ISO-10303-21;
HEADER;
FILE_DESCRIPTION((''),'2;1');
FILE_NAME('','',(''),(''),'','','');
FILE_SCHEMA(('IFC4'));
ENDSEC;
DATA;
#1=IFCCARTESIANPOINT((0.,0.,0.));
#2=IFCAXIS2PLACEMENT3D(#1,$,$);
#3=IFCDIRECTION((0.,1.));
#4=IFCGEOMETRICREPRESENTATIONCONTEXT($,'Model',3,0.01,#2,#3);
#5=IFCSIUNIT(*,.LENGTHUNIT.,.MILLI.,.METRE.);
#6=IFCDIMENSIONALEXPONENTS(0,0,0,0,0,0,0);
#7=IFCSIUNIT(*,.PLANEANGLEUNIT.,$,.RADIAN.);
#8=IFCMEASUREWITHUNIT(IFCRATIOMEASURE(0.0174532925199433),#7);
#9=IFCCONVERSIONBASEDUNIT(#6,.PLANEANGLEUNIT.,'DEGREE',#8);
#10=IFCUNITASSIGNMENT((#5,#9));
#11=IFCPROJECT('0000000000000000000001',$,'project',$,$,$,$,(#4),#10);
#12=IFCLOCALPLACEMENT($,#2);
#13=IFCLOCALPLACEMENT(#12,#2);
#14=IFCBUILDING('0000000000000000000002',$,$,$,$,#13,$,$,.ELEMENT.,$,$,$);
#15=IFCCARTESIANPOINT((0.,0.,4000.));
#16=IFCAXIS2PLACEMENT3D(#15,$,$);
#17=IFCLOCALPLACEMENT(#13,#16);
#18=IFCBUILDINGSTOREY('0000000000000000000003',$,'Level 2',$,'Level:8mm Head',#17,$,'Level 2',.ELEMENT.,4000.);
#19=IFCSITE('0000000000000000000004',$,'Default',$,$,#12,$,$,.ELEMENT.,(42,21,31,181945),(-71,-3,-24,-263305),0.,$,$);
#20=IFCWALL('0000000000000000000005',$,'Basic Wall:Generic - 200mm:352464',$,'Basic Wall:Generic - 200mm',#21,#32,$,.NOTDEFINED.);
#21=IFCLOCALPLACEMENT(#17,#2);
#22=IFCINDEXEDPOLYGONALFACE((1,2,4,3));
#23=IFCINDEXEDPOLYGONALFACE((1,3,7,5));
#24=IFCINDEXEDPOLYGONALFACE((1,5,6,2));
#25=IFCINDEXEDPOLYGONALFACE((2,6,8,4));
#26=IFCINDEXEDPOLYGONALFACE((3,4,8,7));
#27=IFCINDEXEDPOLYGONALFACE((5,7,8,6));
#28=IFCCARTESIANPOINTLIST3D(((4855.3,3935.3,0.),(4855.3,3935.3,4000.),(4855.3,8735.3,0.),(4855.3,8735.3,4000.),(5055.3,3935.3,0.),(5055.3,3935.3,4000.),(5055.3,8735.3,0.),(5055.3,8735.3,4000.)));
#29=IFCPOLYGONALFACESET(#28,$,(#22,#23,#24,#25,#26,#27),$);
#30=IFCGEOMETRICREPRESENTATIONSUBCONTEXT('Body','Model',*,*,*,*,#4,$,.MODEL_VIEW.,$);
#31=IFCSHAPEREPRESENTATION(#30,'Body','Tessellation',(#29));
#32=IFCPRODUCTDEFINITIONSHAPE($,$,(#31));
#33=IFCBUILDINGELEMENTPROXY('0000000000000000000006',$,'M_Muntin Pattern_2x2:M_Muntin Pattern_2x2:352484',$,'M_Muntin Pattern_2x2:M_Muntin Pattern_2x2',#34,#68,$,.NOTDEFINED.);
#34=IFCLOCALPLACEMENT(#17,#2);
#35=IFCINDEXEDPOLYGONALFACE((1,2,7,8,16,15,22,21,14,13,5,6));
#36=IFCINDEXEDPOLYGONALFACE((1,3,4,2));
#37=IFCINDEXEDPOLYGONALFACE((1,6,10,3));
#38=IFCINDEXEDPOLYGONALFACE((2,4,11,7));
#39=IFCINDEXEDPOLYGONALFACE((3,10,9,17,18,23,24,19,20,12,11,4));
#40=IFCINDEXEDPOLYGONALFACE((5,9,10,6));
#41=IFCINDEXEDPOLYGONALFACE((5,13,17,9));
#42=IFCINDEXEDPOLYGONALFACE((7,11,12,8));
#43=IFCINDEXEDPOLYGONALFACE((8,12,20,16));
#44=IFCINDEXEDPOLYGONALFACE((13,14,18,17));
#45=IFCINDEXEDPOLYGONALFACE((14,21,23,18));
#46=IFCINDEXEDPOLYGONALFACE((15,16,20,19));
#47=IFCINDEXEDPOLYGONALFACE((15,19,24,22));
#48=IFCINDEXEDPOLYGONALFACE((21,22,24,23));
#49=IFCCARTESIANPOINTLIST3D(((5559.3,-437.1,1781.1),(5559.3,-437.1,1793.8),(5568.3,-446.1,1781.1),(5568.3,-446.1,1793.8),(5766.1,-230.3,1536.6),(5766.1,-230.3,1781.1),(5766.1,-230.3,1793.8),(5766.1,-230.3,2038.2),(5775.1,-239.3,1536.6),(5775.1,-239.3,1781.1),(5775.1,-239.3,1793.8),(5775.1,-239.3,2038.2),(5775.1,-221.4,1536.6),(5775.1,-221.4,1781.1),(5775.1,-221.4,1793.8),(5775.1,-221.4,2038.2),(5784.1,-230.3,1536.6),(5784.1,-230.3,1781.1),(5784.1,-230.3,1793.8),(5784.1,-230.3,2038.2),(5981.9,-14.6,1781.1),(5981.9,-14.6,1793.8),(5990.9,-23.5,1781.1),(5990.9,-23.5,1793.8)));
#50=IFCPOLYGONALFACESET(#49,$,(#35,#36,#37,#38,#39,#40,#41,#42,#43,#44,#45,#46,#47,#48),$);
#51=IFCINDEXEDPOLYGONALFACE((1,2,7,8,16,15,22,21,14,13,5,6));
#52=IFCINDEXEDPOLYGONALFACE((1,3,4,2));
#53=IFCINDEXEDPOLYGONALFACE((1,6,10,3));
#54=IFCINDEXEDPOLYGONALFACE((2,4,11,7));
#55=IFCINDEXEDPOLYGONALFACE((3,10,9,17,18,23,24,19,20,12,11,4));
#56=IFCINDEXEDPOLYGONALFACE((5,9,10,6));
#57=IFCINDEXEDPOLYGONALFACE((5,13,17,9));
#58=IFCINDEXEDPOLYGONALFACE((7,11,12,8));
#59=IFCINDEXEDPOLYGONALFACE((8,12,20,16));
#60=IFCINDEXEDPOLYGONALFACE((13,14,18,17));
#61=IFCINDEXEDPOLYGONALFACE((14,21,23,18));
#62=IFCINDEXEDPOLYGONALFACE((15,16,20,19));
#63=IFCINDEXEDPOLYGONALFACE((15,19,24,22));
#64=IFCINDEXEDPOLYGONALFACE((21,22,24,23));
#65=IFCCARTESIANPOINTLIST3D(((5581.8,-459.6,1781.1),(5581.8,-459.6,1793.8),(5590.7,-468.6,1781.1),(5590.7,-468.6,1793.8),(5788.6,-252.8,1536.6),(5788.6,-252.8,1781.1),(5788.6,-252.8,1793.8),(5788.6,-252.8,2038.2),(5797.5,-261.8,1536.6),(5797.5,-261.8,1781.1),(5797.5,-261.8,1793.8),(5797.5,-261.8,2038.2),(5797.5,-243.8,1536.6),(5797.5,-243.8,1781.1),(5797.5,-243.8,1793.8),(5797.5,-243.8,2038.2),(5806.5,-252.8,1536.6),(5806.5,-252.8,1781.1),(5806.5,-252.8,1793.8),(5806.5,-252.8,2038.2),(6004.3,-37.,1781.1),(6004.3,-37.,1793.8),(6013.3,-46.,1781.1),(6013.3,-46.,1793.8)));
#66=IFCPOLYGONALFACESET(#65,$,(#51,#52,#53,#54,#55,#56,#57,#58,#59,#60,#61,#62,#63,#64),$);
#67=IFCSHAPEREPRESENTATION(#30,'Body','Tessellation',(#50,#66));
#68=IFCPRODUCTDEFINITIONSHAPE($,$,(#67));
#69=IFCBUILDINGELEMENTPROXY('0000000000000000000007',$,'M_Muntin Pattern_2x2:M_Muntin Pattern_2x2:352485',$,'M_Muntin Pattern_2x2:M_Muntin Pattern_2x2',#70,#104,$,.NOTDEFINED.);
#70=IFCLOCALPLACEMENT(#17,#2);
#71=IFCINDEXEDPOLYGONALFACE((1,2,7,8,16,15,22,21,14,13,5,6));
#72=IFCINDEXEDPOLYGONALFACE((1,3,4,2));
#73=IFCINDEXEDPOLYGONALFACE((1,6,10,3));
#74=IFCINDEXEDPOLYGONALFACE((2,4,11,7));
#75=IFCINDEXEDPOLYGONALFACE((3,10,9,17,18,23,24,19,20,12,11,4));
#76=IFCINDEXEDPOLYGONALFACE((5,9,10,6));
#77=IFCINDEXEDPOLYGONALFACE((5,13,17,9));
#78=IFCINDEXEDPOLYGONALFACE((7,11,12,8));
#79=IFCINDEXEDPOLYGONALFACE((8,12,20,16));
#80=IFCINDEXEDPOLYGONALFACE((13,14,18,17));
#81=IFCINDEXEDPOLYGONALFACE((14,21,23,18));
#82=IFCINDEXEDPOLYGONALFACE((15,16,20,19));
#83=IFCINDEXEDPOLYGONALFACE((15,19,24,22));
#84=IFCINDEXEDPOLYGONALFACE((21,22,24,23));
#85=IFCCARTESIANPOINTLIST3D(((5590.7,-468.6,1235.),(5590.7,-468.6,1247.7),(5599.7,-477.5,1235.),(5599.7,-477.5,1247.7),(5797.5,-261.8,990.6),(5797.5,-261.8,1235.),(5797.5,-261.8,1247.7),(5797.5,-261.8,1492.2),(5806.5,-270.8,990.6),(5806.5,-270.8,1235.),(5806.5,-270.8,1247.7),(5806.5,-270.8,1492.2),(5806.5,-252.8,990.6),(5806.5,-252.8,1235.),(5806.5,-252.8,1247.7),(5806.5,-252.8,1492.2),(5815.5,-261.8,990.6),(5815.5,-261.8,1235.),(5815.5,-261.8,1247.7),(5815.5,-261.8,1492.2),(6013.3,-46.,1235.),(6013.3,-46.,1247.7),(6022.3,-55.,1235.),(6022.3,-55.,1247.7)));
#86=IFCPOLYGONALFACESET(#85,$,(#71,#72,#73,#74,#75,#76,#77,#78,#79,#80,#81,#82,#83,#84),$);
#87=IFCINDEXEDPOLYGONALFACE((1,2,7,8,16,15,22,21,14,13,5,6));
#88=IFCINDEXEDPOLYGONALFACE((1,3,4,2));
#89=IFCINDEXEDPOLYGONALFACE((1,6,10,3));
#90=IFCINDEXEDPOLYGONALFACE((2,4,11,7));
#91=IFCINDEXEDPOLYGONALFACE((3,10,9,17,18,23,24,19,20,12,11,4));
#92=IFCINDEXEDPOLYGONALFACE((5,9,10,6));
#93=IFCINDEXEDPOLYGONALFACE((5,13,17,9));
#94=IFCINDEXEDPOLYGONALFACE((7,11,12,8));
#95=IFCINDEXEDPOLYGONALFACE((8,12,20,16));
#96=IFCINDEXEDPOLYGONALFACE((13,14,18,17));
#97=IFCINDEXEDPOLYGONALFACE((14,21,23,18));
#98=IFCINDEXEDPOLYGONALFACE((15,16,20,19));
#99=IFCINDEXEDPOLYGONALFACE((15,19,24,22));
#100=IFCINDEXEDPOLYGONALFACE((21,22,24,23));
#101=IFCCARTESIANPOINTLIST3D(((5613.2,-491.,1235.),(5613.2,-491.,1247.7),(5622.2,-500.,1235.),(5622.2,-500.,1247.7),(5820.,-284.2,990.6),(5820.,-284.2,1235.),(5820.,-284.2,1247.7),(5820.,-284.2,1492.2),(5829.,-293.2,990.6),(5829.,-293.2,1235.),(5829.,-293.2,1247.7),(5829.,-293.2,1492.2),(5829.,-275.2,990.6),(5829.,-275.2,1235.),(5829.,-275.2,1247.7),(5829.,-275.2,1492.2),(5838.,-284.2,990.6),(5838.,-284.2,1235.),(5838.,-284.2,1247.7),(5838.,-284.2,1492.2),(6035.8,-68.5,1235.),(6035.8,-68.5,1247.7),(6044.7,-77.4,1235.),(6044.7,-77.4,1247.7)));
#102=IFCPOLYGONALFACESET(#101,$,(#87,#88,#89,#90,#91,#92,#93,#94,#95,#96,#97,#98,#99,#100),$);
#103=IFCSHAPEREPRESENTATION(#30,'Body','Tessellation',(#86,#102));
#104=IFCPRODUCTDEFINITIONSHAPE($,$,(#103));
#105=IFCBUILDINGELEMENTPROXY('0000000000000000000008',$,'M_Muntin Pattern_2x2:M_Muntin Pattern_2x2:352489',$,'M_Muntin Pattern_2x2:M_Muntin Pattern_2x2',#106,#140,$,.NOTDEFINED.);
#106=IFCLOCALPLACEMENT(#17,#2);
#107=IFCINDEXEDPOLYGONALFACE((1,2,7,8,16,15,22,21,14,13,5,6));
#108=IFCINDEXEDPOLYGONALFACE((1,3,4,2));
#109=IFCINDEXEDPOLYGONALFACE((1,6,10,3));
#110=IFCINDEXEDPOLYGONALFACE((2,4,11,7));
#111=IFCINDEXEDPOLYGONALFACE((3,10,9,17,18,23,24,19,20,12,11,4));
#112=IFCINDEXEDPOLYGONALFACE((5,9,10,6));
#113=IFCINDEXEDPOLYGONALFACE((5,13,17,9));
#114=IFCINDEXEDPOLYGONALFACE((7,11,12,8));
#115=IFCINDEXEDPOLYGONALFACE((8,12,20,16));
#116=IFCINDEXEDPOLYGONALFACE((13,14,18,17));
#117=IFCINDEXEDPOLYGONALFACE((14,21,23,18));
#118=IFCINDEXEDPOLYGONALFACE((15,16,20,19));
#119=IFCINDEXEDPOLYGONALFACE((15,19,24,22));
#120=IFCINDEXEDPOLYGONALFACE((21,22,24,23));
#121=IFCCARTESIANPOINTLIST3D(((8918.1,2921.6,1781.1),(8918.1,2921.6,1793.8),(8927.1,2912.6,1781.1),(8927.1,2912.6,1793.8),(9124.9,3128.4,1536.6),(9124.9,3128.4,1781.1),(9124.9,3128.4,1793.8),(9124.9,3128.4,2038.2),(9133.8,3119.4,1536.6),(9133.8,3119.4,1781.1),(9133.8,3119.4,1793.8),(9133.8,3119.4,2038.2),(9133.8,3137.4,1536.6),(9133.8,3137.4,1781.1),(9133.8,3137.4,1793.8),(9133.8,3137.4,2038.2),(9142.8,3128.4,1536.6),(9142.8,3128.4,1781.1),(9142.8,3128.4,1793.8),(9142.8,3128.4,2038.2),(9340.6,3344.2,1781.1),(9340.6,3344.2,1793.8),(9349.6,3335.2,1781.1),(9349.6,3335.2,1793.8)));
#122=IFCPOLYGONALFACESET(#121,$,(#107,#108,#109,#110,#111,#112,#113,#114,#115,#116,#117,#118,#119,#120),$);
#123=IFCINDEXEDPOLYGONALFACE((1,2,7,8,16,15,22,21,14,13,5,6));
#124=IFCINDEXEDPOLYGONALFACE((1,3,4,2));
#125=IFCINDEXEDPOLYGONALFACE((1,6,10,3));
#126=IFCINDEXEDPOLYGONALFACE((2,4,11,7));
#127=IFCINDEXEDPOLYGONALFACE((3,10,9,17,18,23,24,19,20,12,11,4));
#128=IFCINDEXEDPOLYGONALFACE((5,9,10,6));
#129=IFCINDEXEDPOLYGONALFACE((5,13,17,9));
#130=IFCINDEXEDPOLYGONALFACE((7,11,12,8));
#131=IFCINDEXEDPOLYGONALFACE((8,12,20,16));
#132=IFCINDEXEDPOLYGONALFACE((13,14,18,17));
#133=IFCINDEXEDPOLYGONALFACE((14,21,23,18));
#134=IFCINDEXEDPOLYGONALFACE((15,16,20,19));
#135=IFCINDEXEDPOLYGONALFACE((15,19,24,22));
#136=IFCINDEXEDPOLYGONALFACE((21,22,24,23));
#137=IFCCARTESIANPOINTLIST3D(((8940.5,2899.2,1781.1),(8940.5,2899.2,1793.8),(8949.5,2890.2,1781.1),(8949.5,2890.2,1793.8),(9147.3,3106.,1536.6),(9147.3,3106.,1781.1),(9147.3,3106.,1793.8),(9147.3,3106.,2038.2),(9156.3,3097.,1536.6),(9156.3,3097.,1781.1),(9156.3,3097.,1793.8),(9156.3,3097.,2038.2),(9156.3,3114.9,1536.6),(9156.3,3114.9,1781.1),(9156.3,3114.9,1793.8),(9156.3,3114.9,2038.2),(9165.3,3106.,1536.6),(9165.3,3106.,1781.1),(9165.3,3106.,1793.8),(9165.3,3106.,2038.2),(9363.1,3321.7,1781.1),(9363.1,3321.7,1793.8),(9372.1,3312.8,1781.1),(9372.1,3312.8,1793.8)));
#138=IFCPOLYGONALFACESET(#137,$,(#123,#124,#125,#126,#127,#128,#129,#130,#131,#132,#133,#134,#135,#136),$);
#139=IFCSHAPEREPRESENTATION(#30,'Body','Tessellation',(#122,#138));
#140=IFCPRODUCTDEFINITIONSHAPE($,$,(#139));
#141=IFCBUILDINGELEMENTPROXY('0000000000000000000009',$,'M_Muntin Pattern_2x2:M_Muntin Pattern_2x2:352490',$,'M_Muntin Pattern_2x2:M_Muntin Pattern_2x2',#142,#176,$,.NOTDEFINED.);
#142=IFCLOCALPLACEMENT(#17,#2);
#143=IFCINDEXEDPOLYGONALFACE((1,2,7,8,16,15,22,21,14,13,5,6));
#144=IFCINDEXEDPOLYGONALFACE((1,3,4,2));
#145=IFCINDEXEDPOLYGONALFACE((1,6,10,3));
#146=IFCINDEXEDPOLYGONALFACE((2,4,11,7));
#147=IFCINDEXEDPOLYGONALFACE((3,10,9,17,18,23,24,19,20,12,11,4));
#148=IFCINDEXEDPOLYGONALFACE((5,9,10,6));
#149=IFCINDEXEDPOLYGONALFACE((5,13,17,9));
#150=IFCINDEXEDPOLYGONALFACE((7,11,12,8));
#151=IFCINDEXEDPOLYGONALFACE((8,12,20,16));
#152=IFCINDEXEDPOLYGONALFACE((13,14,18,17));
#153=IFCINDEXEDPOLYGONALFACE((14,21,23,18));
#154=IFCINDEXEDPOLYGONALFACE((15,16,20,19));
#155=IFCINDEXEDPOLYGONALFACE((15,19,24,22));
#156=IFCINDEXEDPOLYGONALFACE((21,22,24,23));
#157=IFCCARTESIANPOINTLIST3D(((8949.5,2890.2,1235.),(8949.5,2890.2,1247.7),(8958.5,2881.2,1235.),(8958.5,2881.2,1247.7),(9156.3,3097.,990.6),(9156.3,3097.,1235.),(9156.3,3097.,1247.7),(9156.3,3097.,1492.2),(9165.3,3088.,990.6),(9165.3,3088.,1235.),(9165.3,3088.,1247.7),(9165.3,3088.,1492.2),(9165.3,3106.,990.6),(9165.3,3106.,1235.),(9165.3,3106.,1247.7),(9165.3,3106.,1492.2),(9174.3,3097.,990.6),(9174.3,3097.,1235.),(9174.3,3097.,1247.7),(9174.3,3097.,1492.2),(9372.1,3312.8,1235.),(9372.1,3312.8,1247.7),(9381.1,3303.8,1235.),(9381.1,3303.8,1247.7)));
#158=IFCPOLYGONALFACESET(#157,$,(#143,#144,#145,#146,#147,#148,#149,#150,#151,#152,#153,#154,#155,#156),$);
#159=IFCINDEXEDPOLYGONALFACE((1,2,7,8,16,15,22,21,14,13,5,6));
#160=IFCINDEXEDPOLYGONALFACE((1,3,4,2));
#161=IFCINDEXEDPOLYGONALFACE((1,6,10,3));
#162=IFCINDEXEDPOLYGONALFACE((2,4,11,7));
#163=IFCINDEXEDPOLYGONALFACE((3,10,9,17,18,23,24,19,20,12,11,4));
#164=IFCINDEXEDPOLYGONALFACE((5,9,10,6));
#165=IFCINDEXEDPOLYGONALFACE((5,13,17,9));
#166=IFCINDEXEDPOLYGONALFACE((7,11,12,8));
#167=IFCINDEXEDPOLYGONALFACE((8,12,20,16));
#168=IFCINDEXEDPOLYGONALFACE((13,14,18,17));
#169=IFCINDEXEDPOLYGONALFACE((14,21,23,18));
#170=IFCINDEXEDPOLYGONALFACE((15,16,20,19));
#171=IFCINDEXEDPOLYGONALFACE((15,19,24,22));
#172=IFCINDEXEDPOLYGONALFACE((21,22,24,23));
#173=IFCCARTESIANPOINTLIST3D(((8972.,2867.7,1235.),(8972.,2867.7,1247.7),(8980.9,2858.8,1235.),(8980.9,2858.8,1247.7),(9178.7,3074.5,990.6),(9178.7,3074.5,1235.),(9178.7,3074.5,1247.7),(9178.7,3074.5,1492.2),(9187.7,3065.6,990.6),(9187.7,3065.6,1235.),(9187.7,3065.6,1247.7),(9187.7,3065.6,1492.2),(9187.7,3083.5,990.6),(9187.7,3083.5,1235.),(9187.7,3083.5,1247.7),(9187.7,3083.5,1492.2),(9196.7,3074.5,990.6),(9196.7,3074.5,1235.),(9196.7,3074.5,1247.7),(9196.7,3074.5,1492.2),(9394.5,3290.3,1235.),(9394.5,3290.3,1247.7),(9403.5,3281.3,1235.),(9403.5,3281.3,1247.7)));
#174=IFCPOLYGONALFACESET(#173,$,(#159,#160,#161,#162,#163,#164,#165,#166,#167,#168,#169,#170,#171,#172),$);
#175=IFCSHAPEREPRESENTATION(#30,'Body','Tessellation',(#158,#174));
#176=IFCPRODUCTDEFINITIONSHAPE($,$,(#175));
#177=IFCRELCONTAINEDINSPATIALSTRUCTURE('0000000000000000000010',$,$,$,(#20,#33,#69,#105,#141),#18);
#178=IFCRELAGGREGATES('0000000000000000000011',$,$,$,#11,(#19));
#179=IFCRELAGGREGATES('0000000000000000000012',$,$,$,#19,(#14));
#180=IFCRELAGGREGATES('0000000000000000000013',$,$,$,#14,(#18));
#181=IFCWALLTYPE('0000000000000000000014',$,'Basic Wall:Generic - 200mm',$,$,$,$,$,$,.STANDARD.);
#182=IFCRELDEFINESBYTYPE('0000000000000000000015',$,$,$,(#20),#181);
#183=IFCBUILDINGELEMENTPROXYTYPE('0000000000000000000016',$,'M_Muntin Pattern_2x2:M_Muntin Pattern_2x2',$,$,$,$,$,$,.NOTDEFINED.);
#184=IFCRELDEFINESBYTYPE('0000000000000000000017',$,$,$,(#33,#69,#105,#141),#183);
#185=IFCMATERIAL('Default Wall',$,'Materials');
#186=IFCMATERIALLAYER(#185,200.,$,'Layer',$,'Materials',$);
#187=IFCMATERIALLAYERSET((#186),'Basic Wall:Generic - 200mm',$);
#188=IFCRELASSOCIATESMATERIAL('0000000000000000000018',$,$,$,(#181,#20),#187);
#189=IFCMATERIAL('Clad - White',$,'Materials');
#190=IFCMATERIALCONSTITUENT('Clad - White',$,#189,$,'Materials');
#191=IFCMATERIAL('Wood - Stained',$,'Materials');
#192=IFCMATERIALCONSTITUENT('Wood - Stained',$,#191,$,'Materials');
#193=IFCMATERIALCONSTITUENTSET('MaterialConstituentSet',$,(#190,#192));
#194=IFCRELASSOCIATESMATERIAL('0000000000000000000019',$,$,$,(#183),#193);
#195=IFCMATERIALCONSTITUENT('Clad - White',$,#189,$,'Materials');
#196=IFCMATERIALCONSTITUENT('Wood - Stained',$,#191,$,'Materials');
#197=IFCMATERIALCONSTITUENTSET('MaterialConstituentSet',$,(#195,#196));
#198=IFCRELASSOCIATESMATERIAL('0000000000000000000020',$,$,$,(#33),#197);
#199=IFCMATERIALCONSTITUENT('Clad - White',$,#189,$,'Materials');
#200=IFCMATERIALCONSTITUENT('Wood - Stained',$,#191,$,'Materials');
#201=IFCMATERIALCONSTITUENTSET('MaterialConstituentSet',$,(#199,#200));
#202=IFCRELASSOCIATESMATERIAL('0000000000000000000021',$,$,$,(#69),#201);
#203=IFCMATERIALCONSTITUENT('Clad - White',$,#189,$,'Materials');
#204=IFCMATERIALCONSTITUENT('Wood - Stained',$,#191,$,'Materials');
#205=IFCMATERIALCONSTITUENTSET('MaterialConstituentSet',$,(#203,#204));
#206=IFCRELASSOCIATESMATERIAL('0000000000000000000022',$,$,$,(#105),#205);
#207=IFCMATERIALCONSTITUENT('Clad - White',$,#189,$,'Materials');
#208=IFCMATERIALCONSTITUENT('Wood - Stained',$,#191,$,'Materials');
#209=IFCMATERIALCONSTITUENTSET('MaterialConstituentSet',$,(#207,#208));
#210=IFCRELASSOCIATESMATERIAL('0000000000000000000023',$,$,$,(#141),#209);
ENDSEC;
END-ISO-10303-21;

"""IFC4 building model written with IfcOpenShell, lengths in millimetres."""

from ifc_helpers import new_model, entity, si_unit, converted_unit, direction, frame, frame_2d, origin, place, context, subcontext, project, spatial, polyline, rectangle, outline, extrude, source, transform, mapped, material, layer, layer_set, layer_usage, constituent, constituent_set, type_object, type_shapes, element, save


model = new_model("IFC4")

# Units and contexts
model_context = context("Model", 3, precision=0.01, world=origin(), true_north=direction((0.0, 1.0)))
body_context = subcontext(model_context, "Body", "Model", "MODEL_VIEW")
ifc_project = project(units=[si_unit("LENGTHUNIT", "METRE", prefix="MILLI"), converted_unit("PLANEANGLEUNIT", "DEGREE", entity("IfcRatioMeasure", 0.0174532925199433), si_unit("PLANEANGLEUNIT", "RADIAN"), dimensions=[0, 0, 0, 0, 0, 0, 0])], contexts=[model_context])

# Site, building, storey
site_placement = place(None, origin())
site = spatial("IfcSite", under=ifc_project, at=site_placement, Name="Default", CompositionType="ELEMENT", RefLatitude=(42, 21, 31, 181945), RefLongitude=(-71, -3, -24, -263305), RefElevation=0.0)
building_placement = place(site_placement, origin())
building = spatial("IfcBuilding", under=site, at=building_placement, CompositionType="ELEMENT")
storey_placement = place(building_placement, frame((0.0, 0.0, 4000.0)))
storey = spatial("IfcBuildingStorey", under=building, at=storey_placement, Name="Level 2", ObjectType="Level:8mm Head", LongName="Level 2", CompositionType="ELEMENT", Elevation=4000.0)

# Shared definitions
ifc_material_1 = material(Name="Default Wall", Category="Materials")
ifc_layer = layer(ifc_material_1, 200.0, Name="Layer", Category="Materials")
ifc_layer_set = layer_set([ifc_layer], Name="Basic Wall:Generic - 200mm")
wall_type = type_object("IfcWallType", Name="Basic Wall:Generic - 200mm", PredefinedType="STANDARD", material=ifc_layer_set)
ifc_material_2 = material(Name="Wood - Stained", Category="Materials")

# Wall
ifc_layer_usage_1 = layer_usage(ifc_layer_set, "AXIS2", "NEGATIVE", 100.0)
wall_1_placement = place(storey_placement, frame((4955.3, 3935.3, 0.0), z_axis=(0.0, 0.0, 1.0), x_axis=(0.0, 1.0, 0.0)))
element("IfcWall", 1, at=wall_1_placement, inside=storey, type_object=wall_type, material=ifc_layer_usage_1, Name="Basic Wall:Generic - 200mm:352464", ObjectType="Basic Wall:Generic - 200mm", PredefinedType="NOTDEFINED", context=body_context, shape_type="SweptSolid", body=[
    extrude(rectangle(XDim=4800.0, YDim=200.0, at=frame_2d((2400.0, 0.0), x_axis=(-1.0, 0.0))), origin(), (0.0, 0.0, 1.0), 4000.0),
])

# Building element proxies
ifc_material_3 = material(Name="Clad - White", Category="Materials")
ifc_constituent_1 = constituent(ifc_material_3, Name="Clad - White", Category="Materials")
ifc_constituent_2 = constituent(ifc_material_2, Name="Wood - Stained", Category="Materials")
ifc_constituent_set_1 = constituent_set(constituents=[ifc_constituent_1, ifc_constituent_2], Name="MaterialConstituentSet")
ifc_constituent_3 = constituent(ifc_material_3, Name="Clad - White", Category="Materials")
ifc_constituent_4 = constituent(ifc_material_2, Name="Wood - Stained", Category="Materials")
ifc_constituent_set_2 = constituent_set(constituents=[ifc_constituent_3, ifc_constituent_4], Name="MaterialConstituentSet")
building_element_proxy_type_1 = type_object("IfcBuildingElementProxyType", Name="M_Muntin Pattern_2x2:M_Muntin Pattern_2x2", PredefinedType="NOTDEFINED", material=ifc_constituent_set_2)
shared_shape_1 = source(origin(), body_context, "Body", "SweptSolid", [
    extrude(outline(polyline([(6.4, -6.4), (250.8, -6.4), (250.8, 6.3), (6.4, 6.3), (6.4, 298.8), (-6.3, 298.8), (-6.3, 6.3), (-250.8, 6.3), (-250.8, -6.4), (-6.3, -6.4), (-6.3, -298.8), (6.4, -298.8), (6.4, -6.4)])), frame((0.0, 9.5, 250.8), z_axis=(0.0, 1.0, 0.0), x_axis=(0.0, 0.0, 1.0)), (0.0, 0.0, 1.0), 12.7),
    extrude(outline(polyline([(6.4, -6.4), (250.8, -6.4), (250.8, 6.3), (6.4, 6.3), (6.4, 298.8), (-6.3, 298.8), (-6.3, 6.3), (-250.8, 6.3), (-250.8, -6.4), (-6.3, -6.4), (-6.3, -298.8), (6.4, -298.8), (6.4, -6.4)])), frame((0.0, -22.2, 250.8), z_axis=(0.0, 1.0, 0.0), x_axis=(0.0, 0.0, 1.0)), (0.0, 0.0, 1.0), 12.7),
])
type_shapes(building_element_proxy_type_1, [shared_shape_1])
proxy_1_placement = place(storey_placement, frame((5786.3, -241.6, 1536.6), z_axis=(0.0, 0.0, 1.0), x_axis=(0.707107, 0.707107, 0.0)))
element("IfcBuildingElementProxy", 2, at=proxy_1_placement, inside=storey, type_object=building_element_proxy_type_1, material=ifc_constituent_set_1, Name="M_Muntin Pattern_2x2:M_Muntin Pattern_2x2:352484", ObjectType="M_Muntin Pattern_2x2:M_Muntin Pattern_2x2", PredefinedType="NOTDEFINED", context=body_context, shape_type="MappedRepresentation", body=[
    mapped(shared_shape_1, transform((0.0, 0.0, 0.0), scale=1.0)),
])
ifc_constituent_5 = constituent(ifc_material_3, Name="Clad - White", Category="Materials")
ifc_constituent_6 = constituent(ifc_material_2, Name="Wood - Stained", Category="Materials")
ifc_constituent_set_3 = constituent_set(constituents=[ifc_constituent_5, ifc_constituent_6], Name="MaterialConstituentSet")
proxy_2_placement = place(storey_placement, frame((5817.7, -273.0, 990.6), z_axis=(0.0, 0.0, 1.0), x_axis=(0.707107, 0.707107, 0.0)))
element("IfcBuildingElementProxy", 3, at=proxy_2_placement, inside=storey, type_object=building_element_proxy_type_1, material=ifc_constituent_set_3, Name="M_Muntin Pattern_2x2:M_Muntin Pattern_2x2:352485", ObjectType="M_Muntin Pattern_2x2:M_Muntin Pattern_2x2", PredefinedType="NOTDEFINED", context=body_context, shape_type="MappedRepresentation", body=[
    mapped(shared_shape_1, transform((0.0, 0.0, 0.0), scale=1.0)),
])
ifc_constituent_7 = constituent(ifc_material_3, Name="Clad - White", Category="Materials")
ifc_constituent_8 = constituent(ifc_material_2, Name="Wood - Stained", Category="Materials")
ifc_constituent_set_4 = constituent_set(constituents=[ifc_constituent_7, ifc_constituent_8], Name="MaterialConstituentSet")
proxy_3_placement = place(storey_placement, frame((9145.1, 3117.2, 1536.6), z_axis=(0.0, 0.0, 1.0), x_axis=(0.707107, 0.707107, 0.0)))
element("IfcBuildingElementProxy", 4, at=proxy_3_placement, inside=storey, type_object=building_element_proxy_type_1, material=ifc_constituent_set_4, Name="M_Muntin Pattern_2x2:M_Muntin Pattern_2x2:352489", ObjectType="M_Muntin Pattern_2x2:M_Muntin Pattern_2x2", PredefinedType="NOTDEFINED", context=body_context, shape_type="MappedRepresentation", body=[
    mapped(shared_shape_1, transform((0.0, 0.0, 0.0), scale=1.0)),
])
ifc_constituent_9 = constituent(ifc_material_3, Name="Clad - White", Category="Materials")
ifc_constituent_10 = constituent(ifc_material_2, Name="Wood - Stained", Category="Materials")
ifc_constituent_set_5 = constituent_set(constituents=[ifc_constituent_9, ifc_constituent_10], Name="MaterialConstituentSet")
proxy_4_placement = place(storey_placement, frame((9176.5, 3085.8, 990.6), z_axis=(0.0, 0.0, 1.0), x_axis=(0.707107, 0.707107, 0.0)))
element("IfcBuildingElementProxy", 5, at=proxy_4_placement, inside=storey, type_object=building_element_proxy_type_1, material=ifc_constituent_set_5, Name="M_Muntin Pattern_2x2:M_Muntin Pattern_2x2:352490", ObjectType="M_Muntin Pattern_2x2:M_Muntin Pattern_2x2", PredefinedType="NOTDEFINED", context=body_context, shape_type="MappedRepresentation", body=[
    mapped(shared_shape_1, transform((0.0, 0.0, 0.0), scale=1.0)),
])

save(model, "model.ifc")
